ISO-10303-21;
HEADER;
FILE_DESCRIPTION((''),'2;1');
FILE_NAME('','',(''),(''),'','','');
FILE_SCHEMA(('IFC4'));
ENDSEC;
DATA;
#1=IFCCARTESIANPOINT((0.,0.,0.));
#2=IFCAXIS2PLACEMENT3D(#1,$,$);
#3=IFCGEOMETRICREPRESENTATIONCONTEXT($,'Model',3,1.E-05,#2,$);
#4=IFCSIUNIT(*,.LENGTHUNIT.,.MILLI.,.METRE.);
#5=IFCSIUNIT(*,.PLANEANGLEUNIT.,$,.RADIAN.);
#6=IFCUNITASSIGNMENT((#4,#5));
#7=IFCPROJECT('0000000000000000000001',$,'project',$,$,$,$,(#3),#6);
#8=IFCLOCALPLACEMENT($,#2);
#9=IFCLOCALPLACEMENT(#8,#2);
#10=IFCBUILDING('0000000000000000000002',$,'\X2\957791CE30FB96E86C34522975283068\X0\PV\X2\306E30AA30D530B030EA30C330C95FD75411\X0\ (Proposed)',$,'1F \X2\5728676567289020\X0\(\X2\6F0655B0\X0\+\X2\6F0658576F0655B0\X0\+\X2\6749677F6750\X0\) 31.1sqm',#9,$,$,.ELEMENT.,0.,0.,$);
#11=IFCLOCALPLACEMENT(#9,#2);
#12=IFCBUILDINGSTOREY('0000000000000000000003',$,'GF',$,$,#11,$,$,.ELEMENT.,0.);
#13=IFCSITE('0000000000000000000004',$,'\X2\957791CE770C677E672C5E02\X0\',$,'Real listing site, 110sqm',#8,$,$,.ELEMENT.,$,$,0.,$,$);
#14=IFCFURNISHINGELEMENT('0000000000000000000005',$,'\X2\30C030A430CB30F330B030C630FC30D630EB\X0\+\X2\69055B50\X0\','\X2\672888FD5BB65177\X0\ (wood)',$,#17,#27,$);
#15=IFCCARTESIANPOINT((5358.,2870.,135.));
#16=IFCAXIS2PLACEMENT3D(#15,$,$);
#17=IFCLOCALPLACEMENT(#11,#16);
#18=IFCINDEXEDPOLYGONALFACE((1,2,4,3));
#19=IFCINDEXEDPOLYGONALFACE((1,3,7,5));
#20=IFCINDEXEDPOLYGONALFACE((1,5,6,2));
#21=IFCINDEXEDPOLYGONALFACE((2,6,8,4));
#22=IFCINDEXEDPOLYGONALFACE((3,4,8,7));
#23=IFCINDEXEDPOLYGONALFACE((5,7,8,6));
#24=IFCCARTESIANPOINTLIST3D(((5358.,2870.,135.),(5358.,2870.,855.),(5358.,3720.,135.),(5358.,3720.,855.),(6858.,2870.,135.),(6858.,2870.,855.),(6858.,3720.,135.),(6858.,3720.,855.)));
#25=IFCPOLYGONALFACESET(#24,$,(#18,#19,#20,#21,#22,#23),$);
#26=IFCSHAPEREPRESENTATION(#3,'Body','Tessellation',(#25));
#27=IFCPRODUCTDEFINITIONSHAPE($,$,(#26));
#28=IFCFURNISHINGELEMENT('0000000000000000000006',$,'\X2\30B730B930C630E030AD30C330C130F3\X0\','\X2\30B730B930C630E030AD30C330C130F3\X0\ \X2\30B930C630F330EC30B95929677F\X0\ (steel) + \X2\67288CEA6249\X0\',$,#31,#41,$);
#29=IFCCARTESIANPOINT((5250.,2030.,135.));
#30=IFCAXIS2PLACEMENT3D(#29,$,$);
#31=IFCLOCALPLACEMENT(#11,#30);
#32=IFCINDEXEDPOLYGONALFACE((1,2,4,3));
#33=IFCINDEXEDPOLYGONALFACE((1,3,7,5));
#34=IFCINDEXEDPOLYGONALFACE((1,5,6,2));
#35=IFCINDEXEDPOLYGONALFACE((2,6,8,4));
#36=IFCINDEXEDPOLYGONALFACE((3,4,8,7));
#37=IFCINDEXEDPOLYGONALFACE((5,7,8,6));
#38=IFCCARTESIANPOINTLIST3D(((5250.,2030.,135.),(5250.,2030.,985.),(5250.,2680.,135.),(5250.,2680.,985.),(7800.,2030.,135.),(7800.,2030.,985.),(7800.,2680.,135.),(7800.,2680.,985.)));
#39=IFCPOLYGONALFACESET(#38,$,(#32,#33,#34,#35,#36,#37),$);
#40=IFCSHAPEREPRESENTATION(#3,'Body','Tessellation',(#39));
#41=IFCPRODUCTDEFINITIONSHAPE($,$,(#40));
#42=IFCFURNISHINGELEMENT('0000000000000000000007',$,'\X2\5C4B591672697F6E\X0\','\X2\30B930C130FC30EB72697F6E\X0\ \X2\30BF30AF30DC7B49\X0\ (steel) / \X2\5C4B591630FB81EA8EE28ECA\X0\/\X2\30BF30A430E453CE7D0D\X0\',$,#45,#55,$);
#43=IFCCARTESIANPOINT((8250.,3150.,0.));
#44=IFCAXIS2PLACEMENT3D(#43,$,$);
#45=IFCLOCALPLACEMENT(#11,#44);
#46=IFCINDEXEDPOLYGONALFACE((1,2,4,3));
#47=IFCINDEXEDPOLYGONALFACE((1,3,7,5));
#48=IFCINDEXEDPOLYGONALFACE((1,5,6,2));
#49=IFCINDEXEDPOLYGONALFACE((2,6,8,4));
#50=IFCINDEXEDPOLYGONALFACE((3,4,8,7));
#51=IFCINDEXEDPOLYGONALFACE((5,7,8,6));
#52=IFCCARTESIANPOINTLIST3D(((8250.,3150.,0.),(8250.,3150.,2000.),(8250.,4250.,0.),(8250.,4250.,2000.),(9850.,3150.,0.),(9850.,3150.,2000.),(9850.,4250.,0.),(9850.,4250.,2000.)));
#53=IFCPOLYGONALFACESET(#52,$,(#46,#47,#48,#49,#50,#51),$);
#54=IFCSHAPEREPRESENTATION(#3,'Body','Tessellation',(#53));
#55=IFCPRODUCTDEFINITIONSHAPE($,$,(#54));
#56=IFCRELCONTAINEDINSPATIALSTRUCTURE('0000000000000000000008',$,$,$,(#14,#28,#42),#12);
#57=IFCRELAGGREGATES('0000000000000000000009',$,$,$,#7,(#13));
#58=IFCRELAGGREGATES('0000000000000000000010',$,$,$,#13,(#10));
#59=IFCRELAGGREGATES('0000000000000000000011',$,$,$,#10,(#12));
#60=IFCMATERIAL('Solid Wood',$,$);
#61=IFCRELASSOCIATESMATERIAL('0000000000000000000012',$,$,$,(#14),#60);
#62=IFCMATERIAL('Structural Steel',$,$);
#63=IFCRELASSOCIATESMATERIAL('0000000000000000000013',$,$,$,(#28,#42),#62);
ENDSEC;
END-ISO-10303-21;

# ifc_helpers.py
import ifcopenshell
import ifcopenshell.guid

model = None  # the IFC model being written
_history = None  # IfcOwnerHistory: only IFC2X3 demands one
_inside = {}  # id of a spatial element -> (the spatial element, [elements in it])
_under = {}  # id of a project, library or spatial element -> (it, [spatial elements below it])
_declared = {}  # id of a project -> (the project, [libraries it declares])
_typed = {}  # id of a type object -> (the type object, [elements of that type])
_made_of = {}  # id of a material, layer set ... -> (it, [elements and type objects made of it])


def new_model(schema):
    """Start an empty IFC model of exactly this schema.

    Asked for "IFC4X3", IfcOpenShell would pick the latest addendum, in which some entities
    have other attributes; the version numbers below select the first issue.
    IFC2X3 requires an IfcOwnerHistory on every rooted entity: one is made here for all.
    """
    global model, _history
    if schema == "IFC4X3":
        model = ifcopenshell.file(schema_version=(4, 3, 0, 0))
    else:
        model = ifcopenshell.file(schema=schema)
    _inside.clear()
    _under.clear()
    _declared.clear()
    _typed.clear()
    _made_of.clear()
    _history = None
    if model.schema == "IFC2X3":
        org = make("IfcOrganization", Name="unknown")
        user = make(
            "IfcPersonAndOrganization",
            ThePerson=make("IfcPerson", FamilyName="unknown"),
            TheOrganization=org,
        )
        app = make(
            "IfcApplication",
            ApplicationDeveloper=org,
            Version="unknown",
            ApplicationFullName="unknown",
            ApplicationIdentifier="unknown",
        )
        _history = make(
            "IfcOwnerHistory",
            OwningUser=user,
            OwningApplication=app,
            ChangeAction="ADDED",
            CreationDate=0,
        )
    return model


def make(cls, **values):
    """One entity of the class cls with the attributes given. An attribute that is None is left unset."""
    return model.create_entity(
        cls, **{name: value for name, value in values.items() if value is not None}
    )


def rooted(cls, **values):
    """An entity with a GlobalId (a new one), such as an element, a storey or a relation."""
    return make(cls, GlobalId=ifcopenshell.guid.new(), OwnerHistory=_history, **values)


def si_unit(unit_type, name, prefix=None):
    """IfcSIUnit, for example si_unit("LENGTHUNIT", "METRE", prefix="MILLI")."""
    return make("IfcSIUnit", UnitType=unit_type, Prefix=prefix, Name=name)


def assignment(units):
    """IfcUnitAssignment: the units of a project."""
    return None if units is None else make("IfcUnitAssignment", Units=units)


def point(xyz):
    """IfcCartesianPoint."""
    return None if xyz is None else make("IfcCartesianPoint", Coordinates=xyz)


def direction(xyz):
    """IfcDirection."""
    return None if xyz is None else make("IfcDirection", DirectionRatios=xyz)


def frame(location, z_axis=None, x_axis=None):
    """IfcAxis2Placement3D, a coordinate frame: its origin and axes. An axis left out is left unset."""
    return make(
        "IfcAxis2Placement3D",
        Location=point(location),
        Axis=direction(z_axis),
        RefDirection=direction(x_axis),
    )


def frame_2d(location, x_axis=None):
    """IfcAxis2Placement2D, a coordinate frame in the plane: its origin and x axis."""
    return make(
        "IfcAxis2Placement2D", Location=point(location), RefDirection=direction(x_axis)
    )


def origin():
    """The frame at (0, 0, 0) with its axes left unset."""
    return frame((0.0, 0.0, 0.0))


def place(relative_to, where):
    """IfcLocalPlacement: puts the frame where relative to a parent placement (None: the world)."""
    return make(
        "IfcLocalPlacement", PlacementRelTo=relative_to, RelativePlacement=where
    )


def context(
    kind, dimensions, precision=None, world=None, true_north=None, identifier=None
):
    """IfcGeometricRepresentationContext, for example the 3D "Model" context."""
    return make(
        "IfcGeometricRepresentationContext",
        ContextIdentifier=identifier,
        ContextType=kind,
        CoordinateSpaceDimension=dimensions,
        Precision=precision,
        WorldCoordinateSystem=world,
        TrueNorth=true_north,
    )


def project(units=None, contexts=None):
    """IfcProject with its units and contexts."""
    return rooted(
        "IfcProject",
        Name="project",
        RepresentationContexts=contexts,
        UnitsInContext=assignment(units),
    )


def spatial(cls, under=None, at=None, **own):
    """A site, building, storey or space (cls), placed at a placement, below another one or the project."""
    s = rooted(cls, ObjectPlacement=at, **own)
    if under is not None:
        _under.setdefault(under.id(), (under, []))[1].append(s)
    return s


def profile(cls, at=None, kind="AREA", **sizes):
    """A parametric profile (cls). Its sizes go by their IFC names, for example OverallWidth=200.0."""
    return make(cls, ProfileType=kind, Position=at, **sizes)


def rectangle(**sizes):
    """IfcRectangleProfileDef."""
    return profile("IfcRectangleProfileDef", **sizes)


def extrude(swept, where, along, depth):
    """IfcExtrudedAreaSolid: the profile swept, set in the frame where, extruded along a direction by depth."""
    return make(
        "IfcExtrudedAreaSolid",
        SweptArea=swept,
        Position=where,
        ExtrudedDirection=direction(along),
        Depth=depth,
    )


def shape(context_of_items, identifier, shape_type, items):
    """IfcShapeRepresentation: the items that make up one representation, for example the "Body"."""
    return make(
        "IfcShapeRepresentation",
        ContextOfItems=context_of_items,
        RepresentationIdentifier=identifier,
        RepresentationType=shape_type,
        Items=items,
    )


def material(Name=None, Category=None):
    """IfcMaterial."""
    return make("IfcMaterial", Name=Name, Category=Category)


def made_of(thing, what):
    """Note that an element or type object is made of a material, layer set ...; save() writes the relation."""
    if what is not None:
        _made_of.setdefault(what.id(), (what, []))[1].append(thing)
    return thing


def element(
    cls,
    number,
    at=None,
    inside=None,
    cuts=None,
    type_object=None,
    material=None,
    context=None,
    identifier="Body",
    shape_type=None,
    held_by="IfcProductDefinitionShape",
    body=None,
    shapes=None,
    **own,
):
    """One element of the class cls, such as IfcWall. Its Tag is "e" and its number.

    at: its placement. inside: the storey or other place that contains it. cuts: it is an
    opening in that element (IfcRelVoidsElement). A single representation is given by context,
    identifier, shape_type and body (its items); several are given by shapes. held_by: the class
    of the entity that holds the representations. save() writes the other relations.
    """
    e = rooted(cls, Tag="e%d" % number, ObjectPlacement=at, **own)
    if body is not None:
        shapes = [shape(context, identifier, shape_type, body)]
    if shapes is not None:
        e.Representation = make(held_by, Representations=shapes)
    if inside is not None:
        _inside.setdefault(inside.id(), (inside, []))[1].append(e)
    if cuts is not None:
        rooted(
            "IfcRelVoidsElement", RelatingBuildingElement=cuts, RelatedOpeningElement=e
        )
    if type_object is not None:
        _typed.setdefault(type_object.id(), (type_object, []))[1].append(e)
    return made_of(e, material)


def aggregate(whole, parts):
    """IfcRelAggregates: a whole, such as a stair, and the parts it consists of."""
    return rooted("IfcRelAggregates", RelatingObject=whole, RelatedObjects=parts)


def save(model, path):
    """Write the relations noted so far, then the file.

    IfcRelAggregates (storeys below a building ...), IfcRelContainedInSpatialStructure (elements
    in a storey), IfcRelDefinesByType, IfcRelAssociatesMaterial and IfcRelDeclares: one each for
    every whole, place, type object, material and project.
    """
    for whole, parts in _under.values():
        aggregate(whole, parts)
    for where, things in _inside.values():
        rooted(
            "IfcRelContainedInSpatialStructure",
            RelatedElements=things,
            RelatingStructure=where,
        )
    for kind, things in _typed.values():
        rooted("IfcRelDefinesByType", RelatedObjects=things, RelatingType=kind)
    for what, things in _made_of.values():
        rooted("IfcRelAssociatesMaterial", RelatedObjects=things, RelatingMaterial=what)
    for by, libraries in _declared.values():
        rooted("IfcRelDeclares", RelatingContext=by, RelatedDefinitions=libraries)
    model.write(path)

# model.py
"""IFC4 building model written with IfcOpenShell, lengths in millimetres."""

from ifc_helpers import new_model, si_unit, frame, frame_2d, origin, place, context, project, spatial, rectangle, extrude, material, element, save


model = new_model("IFC4")

# Units and contexts
model_context = context("Model", 3, precision=1e-05, world=origin())
ifc_project = project(units=[si_unit("LENGTHUNIT", "METRE", prefix="MILLI"), si_unit("PLANEANGLEUNIT", "RADIAN")], contexts=[model_context])

# Site, building, storey
site_placement = place(None, origin())
site = spatial("IfcSite", under=ifc_project, at=site_placement, Name="長野県松本市", ObjectType="Real listing site, 110sqm", CompositionType="ELEMENT", RefElevation=0.0)
building_placement = place(site_placement, origin())
building = spatial("IfcBuilding", under=site, at=building_placement, Name="長野・雨水利用とPVのオフグリッド志向 (Proposed)", ObjectType="1F 在来木造(漆喰+漆塗漆喰+杉板材) 31.1sqm", CompositionType="ELEMENT", ElevationOfRefHeight=0.0, ElevationOfTerrain=0.0)
storey_placement = place(building_placement, origin())
storey = spatial("IfcBuildingStorey", under=building, at=storey_placement, Name="GF", CompositionType="ELEMENT", Elevation=0.0)

# Shared definitions
ifc_material_1 = material(Name="Solid Wood")

# Shared definitions
ifc_material_2 = material(Name="Structural Steel")

# Furnishing elements
furnishing_1_placement = place(storey_placement, frame((5358.0, 2870.0, 135.0)))
element("IfcFurnishingElement", 1, at=furnishing_1_placement, inside=storey, material=ifc_material_1, Name="ダイニングテーブル+椅子", Description="木製家具 (wood)", context=model_context, shape_type="SweptSolid", body=[
    extrude(rectangle(XDim=1500.0, YDim=850.0, at=frame_2d((750.0, 425.0))), frame((5358.0, 2870.0, 135.0)), (0.0, 0.0, 1.0), 720.0),
])
furnishing_2_placement = place(storey_placement, frame((5250.0, 2030.0, 135.0)))
element("IfcFurnishingElement", 2, at=furnishing_2_placement, inside=storey, material=ifc_material_2, Name="システムキッチン", Description="システムキッチン ステンレス天板 (steel) + 木質扉", context=model_context, shape_type="SweptSolid", body=[
    extrude(rectangle(XDim=2550.0, YDim=650.0, at=frame_2d((1275.0, 325.0))), frame((5250.0, 2030.0, 135.0)), (0.0, 0.0, 1.0), 850.0),
])
furnishing_3_placement = place(storey_placement, frame((8250.0, 3150.0, 0.0)))
element("IfcFurnishingElement", 3, at=furnishing_3_placement, inside=storey, material=ifc_material_2, Name="屋外物置", Description="スチール物置 タクボ等 (steel) / 屋外・自転車/タイヤ収納", context=model_context, shape_type="SweptSolid", body=[
    extrude(rectangle(XDim=1600.0, YDim=1100.0, at=frame_2d((800.0, 550.0))), frame((8250.0, 3150.0, 0.0)), (0.0, 0.0, 1.0), 2000.0),
])

save(model, "model.ifc")
